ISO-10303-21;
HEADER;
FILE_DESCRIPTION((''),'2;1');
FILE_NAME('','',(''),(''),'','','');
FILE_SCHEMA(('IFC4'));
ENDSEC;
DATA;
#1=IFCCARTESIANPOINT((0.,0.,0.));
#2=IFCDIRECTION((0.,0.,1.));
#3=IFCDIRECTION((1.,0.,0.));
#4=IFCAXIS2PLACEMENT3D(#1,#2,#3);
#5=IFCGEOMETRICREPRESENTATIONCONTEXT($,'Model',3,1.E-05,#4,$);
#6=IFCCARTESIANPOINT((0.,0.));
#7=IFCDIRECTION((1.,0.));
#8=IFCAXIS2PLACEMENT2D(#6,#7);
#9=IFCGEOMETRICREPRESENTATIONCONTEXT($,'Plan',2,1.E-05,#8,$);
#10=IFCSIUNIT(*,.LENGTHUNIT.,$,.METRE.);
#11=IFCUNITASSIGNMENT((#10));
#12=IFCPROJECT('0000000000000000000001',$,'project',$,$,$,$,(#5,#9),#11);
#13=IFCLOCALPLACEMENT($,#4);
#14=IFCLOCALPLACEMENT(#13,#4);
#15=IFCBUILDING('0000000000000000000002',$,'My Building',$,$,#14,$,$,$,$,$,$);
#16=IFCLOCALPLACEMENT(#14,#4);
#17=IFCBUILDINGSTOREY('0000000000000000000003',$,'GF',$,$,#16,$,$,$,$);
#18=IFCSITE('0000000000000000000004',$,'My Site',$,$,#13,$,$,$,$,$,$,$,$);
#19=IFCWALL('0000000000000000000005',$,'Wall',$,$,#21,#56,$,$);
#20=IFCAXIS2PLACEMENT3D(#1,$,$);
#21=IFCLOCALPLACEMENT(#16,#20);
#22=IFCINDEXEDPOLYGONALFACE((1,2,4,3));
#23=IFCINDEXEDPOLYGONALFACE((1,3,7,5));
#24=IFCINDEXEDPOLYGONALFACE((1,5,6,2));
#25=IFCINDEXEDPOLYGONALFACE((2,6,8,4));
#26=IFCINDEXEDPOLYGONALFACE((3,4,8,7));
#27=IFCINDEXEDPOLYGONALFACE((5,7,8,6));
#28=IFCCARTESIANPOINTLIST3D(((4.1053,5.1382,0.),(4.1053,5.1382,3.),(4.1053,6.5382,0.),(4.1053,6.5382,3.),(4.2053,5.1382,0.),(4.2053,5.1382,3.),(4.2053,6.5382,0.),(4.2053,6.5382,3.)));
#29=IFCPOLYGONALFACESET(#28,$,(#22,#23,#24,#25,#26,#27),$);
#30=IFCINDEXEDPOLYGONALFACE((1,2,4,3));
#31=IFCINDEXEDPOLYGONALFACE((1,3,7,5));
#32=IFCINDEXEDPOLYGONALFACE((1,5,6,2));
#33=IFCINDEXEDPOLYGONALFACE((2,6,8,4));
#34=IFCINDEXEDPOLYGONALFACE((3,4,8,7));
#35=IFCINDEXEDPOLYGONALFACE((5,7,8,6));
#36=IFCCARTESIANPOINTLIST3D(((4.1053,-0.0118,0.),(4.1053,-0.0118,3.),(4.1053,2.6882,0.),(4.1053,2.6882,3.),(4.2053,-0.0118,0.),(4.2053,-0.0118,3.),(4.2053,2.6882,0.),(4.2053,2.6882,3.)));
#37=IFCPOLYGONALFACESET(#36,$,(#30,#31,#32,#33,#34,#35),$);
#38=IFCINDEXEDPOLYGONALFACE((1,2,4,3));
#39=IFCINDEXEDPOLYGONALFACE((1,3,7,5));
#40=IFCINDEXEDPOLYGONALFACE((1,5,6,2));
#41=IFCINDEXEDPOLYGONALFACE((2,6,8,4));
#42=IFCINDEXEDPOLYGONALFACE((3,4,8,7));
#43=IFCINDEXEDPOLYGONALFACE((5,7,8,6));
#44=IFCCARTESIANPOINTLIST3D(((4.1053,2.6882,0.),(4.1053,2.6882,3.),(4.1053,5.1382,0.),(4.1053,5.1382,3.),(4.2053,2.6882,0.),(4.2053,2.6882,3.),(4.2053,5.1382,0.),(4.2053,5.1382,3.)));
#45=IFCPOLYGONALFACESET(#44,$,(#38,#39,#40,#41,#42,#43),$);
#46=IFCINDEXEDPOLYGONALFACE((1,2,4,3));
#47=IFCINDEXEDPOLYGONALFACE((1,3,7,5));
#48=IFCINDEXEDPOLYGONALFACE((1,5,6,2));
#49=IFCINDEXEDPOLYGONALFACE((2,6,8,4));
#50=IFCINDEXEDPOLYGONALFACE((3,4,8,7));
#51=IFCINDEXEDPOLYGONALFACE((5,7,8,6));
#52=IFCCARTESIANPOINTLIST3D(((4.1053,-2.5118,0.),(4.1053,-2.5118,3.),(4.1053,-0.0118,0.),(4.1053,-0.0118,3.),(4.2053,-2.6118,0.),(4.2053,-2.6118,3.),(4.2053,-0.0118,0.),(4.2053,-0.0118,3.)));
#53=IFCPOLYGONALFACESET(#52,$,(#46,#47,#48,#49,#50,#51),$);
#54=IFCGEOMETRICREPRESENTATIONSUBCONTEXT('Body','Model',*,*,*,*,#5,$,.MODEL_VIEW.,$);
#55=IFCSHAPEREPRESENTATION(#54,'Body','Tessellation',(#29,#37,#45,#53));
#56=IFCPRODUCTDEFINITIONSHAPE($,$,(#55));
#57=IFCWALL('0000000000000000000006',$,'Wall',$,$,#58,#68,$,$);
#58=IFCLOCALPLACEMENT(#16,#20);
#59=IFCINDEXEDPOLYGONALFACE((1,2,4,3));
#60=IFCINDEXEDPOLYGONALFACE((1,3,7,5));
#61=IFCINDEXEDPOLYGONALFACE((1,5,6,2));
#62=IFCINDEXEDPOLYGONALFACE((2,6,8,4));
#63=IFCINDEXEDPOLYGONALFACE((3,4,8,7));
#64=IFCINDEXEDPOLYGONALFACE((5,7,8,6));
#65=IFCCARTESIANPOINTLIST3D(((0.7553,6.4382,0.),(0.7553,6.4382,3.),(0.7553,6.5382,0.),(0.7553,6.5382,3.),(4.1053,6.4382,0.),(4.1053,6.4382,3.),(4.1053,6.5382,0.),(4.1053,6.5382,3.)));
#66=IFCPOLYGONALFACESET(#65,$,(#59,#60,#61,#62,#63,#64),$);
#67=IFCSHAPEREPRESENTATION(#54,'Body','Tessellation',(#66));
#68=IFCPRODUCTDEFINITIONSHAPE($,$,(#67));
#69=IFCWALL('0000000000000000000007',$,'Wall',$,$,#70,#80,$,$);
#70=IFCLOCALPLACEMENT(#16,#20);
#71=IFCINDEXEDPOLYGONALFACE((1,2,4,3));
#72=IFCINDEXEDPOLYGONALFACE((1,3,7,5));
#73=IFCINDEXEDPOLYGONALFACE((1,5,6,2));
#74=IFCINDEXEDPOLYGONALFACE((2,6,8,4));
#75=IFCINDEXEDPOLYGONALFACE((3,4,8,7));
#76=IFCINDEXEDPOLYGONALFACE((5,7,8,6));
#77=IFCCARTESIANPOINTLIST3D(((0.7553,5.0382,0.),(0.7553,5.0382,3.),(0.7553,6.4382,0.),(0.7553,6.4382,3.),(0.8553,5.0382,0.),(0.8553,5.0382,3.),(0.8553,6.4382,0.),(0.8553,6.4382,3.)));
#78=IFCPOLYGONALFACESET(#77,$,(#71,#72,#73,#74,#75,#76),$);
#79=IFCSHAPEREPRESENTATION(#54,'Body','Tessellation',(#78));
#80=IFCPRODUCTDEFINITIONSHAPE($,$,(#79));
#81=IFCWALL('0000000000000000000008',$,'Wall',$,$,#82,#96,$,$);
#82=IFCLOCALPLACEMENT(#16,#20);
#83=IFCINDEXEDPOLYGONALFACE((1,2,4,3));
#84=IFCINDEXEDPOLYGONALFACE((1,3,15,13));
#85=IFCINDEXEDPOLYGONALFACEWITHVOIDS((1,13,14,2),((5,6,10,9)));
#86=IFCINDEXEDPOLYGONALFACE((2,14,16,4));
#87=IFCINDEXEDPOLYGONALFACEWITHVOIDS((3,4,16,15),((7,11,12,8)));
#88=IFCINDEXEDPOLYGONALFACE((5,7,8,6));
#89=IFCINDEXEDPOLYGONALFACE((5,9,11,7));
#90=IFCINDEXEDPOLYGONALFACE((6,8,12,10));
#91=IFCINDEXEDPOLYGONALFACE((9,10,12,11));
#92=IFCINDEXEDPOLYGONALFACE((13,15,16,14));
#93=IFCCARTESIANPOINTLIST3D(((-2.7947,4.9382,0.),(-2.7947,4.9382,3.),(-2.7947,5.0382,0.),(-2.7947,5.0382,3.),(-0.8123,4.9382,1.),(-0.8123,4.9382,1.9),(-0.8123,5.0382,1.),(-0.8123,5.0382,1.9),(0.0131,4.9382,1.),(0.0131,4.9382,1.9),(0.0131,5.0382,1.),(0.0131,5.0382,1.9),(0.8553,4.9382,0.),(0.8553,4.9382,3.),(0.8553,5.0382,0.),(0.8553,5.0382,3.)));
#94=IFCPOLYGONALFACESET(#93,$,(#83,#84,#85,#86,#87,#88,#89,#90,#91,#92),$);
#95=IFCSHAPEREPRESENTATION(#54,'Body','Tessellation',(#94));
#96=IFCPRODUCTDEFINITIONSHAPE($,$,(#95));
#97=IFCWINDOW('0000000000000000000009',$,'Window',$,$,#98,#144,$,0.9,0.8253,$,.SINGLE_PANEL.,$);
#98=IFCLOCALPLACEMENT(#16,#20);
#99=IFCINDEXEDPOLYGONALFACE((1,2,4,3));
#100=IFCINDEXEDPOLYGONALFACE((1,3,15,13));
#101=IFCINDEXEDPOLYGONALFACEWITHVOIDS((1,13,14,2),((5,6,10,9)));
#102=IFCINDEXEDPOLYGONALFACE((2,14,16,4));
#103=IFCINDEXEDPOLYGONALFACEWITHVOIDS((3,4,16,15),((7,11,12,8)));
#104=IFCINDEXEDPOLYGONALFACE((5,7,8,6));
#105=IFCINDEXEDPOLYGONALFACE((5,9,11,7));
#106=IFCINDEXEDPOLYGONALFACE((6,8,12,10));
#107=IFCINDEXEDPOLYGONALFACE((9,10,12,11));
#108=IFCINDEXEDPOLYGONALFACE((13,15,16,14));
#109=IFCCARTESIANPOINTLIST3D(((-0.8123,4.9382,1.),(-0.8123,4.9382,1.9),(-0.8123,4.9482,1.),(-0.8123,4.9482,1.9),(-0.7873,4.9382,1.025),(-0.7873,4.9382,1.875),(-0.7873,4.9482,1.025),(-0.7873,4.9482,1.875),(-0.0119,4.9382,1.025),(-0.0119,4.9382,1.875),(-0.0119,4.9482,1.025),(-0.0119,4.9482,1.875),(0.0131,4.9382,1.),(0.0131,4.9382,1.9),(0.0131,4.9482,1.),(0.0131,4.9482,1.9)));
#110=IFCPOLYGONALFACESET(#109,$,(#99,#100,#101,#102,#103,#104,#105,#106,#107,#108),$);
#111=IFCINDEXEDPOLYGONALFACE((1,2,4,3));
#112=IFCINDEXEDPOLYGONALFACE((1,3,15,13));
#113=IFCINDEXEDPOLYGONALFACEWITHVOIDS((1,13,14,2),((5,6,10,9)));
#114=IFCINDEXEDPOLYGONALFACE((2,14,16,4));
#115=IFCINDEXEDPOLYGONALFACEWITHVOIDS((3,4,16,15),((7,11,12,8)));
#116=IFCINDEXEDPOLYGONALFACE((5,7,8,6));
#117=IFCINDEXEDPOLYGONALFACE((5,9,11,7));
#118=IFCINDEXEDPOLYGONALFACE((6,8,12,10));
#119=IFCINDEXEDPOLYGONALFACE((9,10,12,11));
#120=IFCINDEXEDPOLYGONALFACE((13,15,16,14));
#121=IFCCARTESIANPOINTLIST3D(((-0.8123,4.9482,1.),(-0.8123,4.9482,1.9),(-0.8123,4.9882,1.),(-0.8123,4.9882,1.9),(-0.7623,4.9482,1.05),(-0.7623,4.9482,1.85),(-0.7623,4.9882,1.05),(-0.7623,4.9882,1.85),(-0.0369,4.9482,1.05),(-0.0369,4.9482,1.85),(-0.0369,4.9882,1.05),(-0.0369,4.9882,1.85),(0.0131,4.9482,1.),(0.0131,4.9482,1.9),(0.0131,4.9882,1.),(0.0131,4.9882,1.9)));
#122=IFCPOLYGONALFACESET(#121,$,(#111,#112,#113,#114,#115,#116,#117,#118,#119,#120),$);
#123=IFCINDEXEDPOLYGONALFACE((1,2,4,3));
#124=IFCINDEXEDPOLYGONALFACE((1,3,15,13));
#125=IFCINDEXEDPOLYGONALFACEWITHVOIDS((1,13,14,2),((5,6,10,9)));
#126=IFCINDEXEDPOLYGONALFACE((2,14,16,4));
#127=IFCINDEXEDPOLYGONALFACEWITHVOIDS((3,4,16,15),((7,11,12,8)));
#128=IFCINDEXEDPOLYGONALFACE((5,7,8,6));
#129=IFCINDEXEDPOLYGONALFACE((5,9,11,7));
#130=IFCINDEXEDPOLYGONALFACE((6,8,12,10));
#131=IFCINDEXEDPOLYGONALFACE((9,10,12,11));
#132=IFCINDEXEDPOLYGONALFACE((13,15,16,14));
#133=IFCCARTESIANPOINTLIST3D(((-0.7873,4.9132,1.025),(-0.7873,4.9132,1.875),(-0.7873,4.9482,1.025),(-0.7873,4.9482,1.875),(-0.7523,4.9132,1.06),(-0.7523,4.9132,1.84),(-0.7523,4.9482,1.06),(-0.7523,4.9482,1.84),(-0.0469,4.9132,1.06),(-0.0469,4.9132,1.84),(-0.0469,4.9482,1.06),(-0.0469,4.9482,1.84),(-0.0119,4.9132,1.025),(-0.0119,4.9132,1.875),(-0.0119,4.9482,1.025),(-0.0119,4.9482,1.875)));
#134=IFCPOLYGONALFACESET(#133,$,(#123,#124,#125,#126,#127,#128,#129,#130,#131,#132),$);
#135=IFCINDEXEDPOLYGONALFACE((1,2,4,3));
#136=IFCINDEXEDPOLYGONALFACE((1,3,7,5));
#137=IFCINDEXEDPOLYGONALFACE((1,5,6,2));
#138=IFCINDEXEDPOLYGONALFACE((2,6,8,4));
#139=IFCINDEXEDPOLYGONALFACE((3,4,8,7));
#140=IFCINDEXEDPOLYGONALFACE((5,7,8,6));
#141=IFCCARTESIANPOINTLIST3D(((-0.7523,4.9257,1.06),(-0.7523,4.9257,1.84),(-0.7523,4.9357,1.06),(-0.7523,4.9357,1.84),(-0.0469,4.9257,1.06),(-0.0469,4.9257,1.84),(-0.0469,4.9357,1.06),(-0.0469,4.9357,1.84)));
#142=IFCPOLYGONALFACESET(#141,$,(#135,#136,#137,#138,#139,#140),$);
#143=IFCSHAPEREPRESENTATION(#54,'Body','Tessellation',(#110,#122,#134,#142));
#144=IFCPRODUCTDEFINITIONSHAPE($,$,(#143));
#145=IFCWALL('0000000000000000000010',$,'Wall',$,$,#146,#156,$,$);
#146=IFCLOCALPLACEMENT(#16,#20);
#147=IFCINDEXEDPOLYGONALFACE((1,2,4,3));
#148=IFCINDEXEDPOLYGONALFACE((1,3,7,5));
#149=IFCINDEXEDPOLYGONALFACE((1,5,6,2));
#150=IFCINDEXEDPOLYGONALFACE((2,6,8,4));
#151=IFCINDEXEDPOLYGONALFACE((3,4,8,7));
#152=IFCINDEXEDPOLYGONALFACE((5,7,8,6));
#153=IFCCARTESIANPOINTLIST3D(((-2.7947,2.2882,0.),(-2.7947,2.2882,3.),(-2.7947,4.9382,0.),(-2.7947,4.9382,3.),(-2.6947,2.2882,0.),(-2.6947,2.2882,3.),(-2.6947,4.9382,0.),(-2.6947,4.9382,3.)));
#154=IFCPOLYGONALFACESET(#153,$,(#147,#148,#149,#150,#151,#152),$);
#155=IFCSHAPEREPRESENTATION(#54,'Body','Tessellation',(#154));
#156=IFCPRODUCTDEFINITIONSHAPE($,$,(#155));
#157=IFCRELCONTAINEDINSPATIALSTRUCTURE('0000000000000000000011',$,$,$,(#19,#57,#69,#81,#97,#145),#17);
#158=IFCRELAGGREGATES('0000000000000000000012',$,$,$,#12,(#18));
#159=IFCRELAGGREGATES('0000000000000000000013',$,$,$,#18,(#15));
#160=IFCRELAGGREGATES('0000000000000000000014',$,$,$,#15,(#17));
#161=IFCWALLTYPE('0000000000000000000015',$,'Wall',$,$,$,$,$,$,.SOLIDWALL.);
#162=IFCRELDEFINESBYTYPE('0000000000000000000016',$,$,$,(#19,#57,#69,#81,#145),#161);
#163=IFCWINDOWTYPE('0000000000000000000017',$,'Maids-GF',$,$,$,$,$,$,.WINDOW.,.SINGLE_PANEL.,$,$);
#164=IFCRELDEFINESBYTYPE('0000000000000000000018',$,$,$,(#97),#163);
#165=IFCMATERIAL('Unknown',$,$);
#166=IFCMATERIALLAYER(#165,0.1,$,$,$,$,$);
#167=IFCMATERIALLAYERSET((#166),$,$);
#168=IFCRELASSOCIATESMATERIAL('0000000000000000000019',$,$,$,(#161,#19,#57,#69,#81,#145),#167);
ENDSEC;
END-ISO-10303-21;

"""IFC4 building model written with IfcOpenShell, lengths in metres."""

from ifc_helpers import new_model, entity, si_unit, frame, origin_with_axes, origin_2d_with_axis, place, context, subcontext, project, spatial, line, indexed_curve, outline, extrude, shape, source, transform, mapped, material, layer, layer_set, layer_usage, type_object, type_shapes, element, fill, save


model = new_model("IFC4")

# Units and contexts
model_context = context("Model", 3, precision=1e-05, world=origin_with_axes())
plan_context = context("Plan", 2, precision=1e-05, world=origin_2d_with_axis())
body_context_1 = subcontext(model_context, "Body", "Model", "MODEL_VIEW")
body_context_2 = subcontext(plan_context, "Body", "Plan", "PLAN_VIEW")
ifc_project = project(units=[si_unit("LENGTHUNIT", "METRE")], contexts=[model_context, plan_context])

# Site, building, storey
site_placement = place(None, origin_with_axes())
site = spatial("IfcSite", under=ifc_project, at=site_placement, Name="My Site")
building_placement = place(site_placement, origin_with_axes())
building = spatial("IfcBuilding", under=site, at=building_placement, Name="My Building")
storey_placement = place(building_placement, origin_with_axes())
storey = spatial("IfcBuildingStorey", under=building, at=storey_placement, Name="GF")

# Shared definitions
ifc_material_1 = material(Name="Unknown")

# Shared definitions
ifc_layer_1 = layer(ifc_material_1, 0.1)
ifc_layer_set_1 = layer_set([ifc_layer_1])
wall_type = type_object("IfcWallType", Name="Wall", PredefinedType="SOLIDWALL", material=ifc_layer_set_1)

# Walls
ifc_layer_usage_1 = layer_usage(ifc_layer_set_1, "AXIS2", "POSITIVE", 0.0)
wall_1_placement = place(storey_placement, frame((4.2053, 5.1382, 0.0), z_axis=(0.0, 0.0, 1.0), x_axis=(0.0, 1.0, 0.0)))
element("IfcWall", 1, at=wall_1_placement, inside=storey, type_object=wall_type, material=ifc_layer_usage_1, Name="Wall", context=body_context_1, shape_type="SweptSolid", body=[
    extrude(outline(indexed_curve([(0.0, 0.0), (0.0, 0.1), (1.4, 0.1), (1.4, 0.0)], segments=[line(1, 2, 3, 4, 1)])), origin_with_axes(), (0.0, 0.0, 1.0), 3.0),
    extrude(outline(indexed_curve([(0.0, 0.0), (0.0, 0.1), (2.7, 0.1), (2.7, 0.0)], segments=[line(1, 2, 3, 4, 1)])), frame((-5.15, 0.0, 0.0), z_axis=(0.0, 0.0, 1.0), x_axis=(1.0, 0.0, 0.0)), (0.0, 0.0, 1.0), 3.0),
    extrude(outline(indexed_curve([(0.0, 0.0), (0.0, 0.1), (2.45, 0.1), (2.45, 0.0)], segments=[line(1, 2, 3, 4, 1)])), frame((-2.45, 0.0, 0.0), z_axis=(0.0, 0.0, 1.0), x_axis=(1.0, 0.0, 0.0)), (0.0, 0.0, 1.0), 3.0),
    extrude(outline(indexed_curve([(0.0, 0.0), (0.1, 0.1), (2.6, 0.1), (2.6, 0.0)], segments=[line(1, 2, 3, 4, 1)])), frame((-7.75, 0.0, 0.0), z_axis=(0.0, 0.0, 1.0), x_axis=(1.0, 0.0, 0.0)), (0.0, 0.0, 1.0), 3.0),
])
ifc_layer_usage_2 = layer_usage(ifc_layer_set_1, "AXIS2", "POSITIVE", 0.0)
wall_2_placement = place(storey_placement, frame((4.1053, 6.5382, 0.0), z_axis=(0.0, 0.0, 1.0), x_axis=(-1.0, 0.0, 0.0)))
element("IfcWall", 2, at=wall_2_placement, inside=storey, type_object=wall_type, material=ifc_layer_usage_2, Name="Wall", context=body_context_1, shape_type="SweptSolid", body=[
    extrude(outline(indexed_curve([(0.0, 0.0), (0.0, 0.1), (3.35, 0.1), (3.35, 0.0)], segments=[line(1, 2, 3, 4, 1)])), origin_with_axes(), (0.0, 0.0, 1.0), 3.0),
])
ifc_layer_usage_3 = layer_usage(ifc_layer_set_1, "AXIS2", "POSITIVE", 0.0)
wall_3_placement = place(storey_placement, frame((0.7553, 6.4382, 0.0), z_axis=(0.0, 0.0, 1.0), x_axis=(0.0, -1.0, 0.0)))
element("IfcWall", 3, at=wall_3_placement, inside=storey, type_object=wall_type, material=ifc_layer_usage_3, Name="Wall", context=body_context_1, shape_type="SweptSolid", body=[
    extrude(outline(indexed_curve([(0.0, 0.0), (0.0, 0.1), (1.4, 0.1), (1.4, 0.0)], segments=[line(1, 2, 3, 4, 1)])), origin_with_axes(), (0.0, 0.0, 1.0), 3.0),
])

# Wall, opening, window
ifc_layer_usage_4 = layer_usage(ifc_layer_set_1, "AXIS2", "POSITIVE", 0.0)
wall_4_placement = place(storey_placement, frame((0.8553, 5.0382, 0.0), z_axis=(0.0, 0.0, 1.0), x_axis=(-1.0, 0.0, 0.0)))
wall_4 = element("IfcWall", 4, at=wall_4_placement, inside=storey, type_object=wall_type, material=ifc_layer_usage_4, Name="Wall", context=body_context_1, shape_type="SweptSolid", body=[
    extrude(outline(indexed_curve([(0.0, 0.0), (0.0, 0.1), (3.65, 0.1), (3.65, 0.0)], segments=[line(1, 2, 3, 4, 1)])), origin_with_axes(), (0.0, 0.0, 1.0), 3.0),
])
shared_shape_1 = source(origin_with_axes(), body_context_1, "Body", "SweptSolid", [
    extrude(outline(indexed_curve([(0.0, 0.0), (0.8253, 0.0), (0.8253, 0.9), (0.0, 0.9)], segments=[line(1, 2, 3, 4, 1)])), frame((0.0, -0.6, 0.0), z_axis=(0.0, -1.0, 0.0), x_axis=(1.0, 0.0, 0.0)), (0.0, 0.0, -1.0), 1.2),
])
opening_1_placement = place(wall_4_placement, frame((0.8422, 0.0, 1.0), z_axis=(0.0, 0.0, 1.0), x_axis=(1.0, -0.000001, 0.0)))
opening_1 = element("IfcOpeningElement", 5, at=opening_1_placement, cuts=wall_4, PredefinedType="OPENING", context=body_context_1, shape_type="MappedRepresentation", body=[
    mapped(shared_shape_1, transform((0.0, 0.0, 0.0), x_axis=(1.0, 0.0, 0.0), y_axis=(0.0, 1.0, 0.0), z_axis=(0.0, 0.0, 1.0), scale=1.0)),
])
window_type_1 = type_object("IfcWindowType", Name="Maids-GF", PartitioningType="SINGLE_PANEL", PredefinedType="WINDOW")
shared_shape_2 = source(origin_with_axes(), body_context_1, "Body", "SweptSolid", [
    extrude(outline(indexed_curve([(0.0, 0.0), (0.8253, 0.0), (0.8253, 0.9), (0.0, 0.9)], segments=[line(1, 2, 3, 4, 1)]), holes=[indexed_curve([(0.025, 0.025), (0.8003, 0.025), (0.8003, 0.875), (0.025, 0.875)], segments=[line(1, 2, 3, 4, 1)])]), frame((0.0, 0.09, 0.0), z_axis=(0.0, -1.0, 0.0), x_axis=(1.0, 0.0, 0.0)), (0.0, 0.0, -1.0), 0.01),
    extrude(outline(indexed_curve([(0.0, 0.0), (0.8253, 0.0), (0.8253, 0.9), (0.0, 0.9)], segments=[line(1, 2, 3, 4, 1)]), holes=[indexed_curve([(0.05, 0.05), (0.7753, 0.05), (0.7753, 0.85), (0.05, 0.85)], segments=[line(1, 2, 3, 4, 1)])]), frame((0.0, 0.05, 0.0), z_axis=(0.0, -1.0, 0.0), x_axis=(1.0, 0.0, 0.0)), (0.0, 0.0, -1.0), 0.04),
    extrude(outline(indexed_curve([(0.0, 0.0), (0.7753, 0.0), (0.7753, 0.85), (0.0, 0.85)], segments=[line(1, 2, 3, 4, 1)]), holes=[indexed_curve([(0.035, 0.035), (0.7403, 0.035), (0.7403, 0.815), (0.035, 0.815)], segments=[line(1, 2, 3, 4, 1)])]), frame((0.025, 0.09, 0.025), z_axis=(0.0, -1.0, 0.0), x_axis=(1.0, 0.0, 0.0)), (0.0, 0.0, -1.0), 0.035),
    extrude(outline(indexed_curve([(0.035, 0.035), (0.7403, 0.035), (0.7403, 0.815), (0.035, 0.815)], segments=[line(1, 2, 3, 4, 1)])), frame((0.025, 0.1025, 0.025), z_axis=(0.0, -1.0, 0.0), x_axis=(1.0, 0.0, 0.0)), (0.0, 0.0, -1.0), 0.01),
])
shared_shape_3 = source(origin_with_axes(), body_context_2, "Body", "Curve2D", [
    entity("IfcIndexedPolyCurve", entity("IfcCartesianPointList2D", [[0.05, 0.05], [0.7753, 0.05]])),
    entity("IfcIndexedPolyCurve", entity("IfcCartesianPointList2D", [[0.0, 0.1], [0.025, 0.1], [0.025, 0.09], [0.05, 0.09], [0.05, 0.05], [0.0, 0.05]]), [entity("IfcLineIndex", [1, 2, 3, 4, 5, 6, 1])]),
    entity("IfcIndexedPolyCurve", entity("IfcCartesianPointList2D", [[0.8253, 0.1], [0.8003, 0.1], [0.8003, 0.09], [0.7753, 0.09], [0.7753, 0.05], [0.8253, 0.05]]), [entity("IfcLineIndex", [1, 2, 3, 4, 5, 6, 1])]),
    entity("IfcIndexedPolyCurve", entity("IfcCartesianPointList2D", [[0.025, 0.09], [0.06, 0.09], [0.06, 0.125], [0.025, 0.125]]), [entity("IfcLineIndex", [1, 2, 3, 4, 1])]),
    entity("IfcIndexedPolyCurve", entity("IfcCartesianPointList2D", [[0.8003, 0.09], [0.7653, 0.09], [0.7653, 0.125], [0.8003, 0.125]]), [entity("IfcLineIndex", [1, 2, 3, 4, 1])]),
    entity("IfcIndexedPolyCurve", entity("IfcCartesianPointList2D", [[0.06, 0.09], [0.7653, 0.09]])),
    entity("IfcIndexedPolyCurve", entity("IfcCartesianPointList2D", [[0.06, 0.125], [0.7653, 0.125]])),
    entity("IfcIndexedPolyCurve", entity("IfcCartesianPointList2D", [[0.06, 0.1075], [0.7653, 0.1075]])),
])
type_shapes(window_type_1, [shared_shape_2, shared_shape_3])
window_1_placement = place(opening_1_placement, frame((0.0, 0.0, 0.0), z_axis=(0.0, 0.0, 1.0), x_axis=(1.0, 0.0, 0.0)))
window_1 = element("IfcWindow", 6, at=window_1_placement, inside=storey, type_object=window_type_1, Name="Window", OverallHeight=0.9, OverallWidth=0.8253, PartitioningType="SINGLE_PANEL", shapes=[
    shape(body_context_1, "Body", "MappedRepresentation", [mapped(shared_shape_2, transform((0.0, 0.0, 0.0), x_axis=(1.0, 0.0, 0.0), y_axis=(0.0, 1.0, 0.0), z_axis=(0.0, 0.0, 1.0), scale=1.0))]),
    shape(body_context_2, "Body", "MappedRepresentation", [mapped(shared_shape_3, transform((0.0, 0.0, 0.0), x_axis=(1.0, 0.0, 0.0), y_axis=(0.0, 1.0, 0.0), z_axis=(0.0, 0.0, 1.0), scale=1.0))]),
])
fill(opening_1, window_1)

# Wall
ifc_layer_usage_5 = layer_usage(ifc_layer_set_1, "AXIS2", "POSITIVE", 0.0)
wall_5_placement = place(storey_placement, frame((-2.7947, 4.9382, 0.0), z_axis=(0.0, 0.0, 1.0), x_axis=(0.0, -1.0, 0.0)))
element("IfcWall", 7, at=wall_5_placement, inside=storey, type_object=wall_type, material=ifc_layer_usage_5, Name="Wall", context=body_context_1, shape_type="SweptSolid", body=[
    extrude(outline(indexed_curve([(0.0, 0.0), (0.0, 0.1), (2.65, 0.1), (2.65, 0.0)], segments=[line(1, 2, 3, 4, 1)])), origin_with_axes(), (0.0, 0.0, 1.0), 3.0),
])

save(model, "model.ifc")
